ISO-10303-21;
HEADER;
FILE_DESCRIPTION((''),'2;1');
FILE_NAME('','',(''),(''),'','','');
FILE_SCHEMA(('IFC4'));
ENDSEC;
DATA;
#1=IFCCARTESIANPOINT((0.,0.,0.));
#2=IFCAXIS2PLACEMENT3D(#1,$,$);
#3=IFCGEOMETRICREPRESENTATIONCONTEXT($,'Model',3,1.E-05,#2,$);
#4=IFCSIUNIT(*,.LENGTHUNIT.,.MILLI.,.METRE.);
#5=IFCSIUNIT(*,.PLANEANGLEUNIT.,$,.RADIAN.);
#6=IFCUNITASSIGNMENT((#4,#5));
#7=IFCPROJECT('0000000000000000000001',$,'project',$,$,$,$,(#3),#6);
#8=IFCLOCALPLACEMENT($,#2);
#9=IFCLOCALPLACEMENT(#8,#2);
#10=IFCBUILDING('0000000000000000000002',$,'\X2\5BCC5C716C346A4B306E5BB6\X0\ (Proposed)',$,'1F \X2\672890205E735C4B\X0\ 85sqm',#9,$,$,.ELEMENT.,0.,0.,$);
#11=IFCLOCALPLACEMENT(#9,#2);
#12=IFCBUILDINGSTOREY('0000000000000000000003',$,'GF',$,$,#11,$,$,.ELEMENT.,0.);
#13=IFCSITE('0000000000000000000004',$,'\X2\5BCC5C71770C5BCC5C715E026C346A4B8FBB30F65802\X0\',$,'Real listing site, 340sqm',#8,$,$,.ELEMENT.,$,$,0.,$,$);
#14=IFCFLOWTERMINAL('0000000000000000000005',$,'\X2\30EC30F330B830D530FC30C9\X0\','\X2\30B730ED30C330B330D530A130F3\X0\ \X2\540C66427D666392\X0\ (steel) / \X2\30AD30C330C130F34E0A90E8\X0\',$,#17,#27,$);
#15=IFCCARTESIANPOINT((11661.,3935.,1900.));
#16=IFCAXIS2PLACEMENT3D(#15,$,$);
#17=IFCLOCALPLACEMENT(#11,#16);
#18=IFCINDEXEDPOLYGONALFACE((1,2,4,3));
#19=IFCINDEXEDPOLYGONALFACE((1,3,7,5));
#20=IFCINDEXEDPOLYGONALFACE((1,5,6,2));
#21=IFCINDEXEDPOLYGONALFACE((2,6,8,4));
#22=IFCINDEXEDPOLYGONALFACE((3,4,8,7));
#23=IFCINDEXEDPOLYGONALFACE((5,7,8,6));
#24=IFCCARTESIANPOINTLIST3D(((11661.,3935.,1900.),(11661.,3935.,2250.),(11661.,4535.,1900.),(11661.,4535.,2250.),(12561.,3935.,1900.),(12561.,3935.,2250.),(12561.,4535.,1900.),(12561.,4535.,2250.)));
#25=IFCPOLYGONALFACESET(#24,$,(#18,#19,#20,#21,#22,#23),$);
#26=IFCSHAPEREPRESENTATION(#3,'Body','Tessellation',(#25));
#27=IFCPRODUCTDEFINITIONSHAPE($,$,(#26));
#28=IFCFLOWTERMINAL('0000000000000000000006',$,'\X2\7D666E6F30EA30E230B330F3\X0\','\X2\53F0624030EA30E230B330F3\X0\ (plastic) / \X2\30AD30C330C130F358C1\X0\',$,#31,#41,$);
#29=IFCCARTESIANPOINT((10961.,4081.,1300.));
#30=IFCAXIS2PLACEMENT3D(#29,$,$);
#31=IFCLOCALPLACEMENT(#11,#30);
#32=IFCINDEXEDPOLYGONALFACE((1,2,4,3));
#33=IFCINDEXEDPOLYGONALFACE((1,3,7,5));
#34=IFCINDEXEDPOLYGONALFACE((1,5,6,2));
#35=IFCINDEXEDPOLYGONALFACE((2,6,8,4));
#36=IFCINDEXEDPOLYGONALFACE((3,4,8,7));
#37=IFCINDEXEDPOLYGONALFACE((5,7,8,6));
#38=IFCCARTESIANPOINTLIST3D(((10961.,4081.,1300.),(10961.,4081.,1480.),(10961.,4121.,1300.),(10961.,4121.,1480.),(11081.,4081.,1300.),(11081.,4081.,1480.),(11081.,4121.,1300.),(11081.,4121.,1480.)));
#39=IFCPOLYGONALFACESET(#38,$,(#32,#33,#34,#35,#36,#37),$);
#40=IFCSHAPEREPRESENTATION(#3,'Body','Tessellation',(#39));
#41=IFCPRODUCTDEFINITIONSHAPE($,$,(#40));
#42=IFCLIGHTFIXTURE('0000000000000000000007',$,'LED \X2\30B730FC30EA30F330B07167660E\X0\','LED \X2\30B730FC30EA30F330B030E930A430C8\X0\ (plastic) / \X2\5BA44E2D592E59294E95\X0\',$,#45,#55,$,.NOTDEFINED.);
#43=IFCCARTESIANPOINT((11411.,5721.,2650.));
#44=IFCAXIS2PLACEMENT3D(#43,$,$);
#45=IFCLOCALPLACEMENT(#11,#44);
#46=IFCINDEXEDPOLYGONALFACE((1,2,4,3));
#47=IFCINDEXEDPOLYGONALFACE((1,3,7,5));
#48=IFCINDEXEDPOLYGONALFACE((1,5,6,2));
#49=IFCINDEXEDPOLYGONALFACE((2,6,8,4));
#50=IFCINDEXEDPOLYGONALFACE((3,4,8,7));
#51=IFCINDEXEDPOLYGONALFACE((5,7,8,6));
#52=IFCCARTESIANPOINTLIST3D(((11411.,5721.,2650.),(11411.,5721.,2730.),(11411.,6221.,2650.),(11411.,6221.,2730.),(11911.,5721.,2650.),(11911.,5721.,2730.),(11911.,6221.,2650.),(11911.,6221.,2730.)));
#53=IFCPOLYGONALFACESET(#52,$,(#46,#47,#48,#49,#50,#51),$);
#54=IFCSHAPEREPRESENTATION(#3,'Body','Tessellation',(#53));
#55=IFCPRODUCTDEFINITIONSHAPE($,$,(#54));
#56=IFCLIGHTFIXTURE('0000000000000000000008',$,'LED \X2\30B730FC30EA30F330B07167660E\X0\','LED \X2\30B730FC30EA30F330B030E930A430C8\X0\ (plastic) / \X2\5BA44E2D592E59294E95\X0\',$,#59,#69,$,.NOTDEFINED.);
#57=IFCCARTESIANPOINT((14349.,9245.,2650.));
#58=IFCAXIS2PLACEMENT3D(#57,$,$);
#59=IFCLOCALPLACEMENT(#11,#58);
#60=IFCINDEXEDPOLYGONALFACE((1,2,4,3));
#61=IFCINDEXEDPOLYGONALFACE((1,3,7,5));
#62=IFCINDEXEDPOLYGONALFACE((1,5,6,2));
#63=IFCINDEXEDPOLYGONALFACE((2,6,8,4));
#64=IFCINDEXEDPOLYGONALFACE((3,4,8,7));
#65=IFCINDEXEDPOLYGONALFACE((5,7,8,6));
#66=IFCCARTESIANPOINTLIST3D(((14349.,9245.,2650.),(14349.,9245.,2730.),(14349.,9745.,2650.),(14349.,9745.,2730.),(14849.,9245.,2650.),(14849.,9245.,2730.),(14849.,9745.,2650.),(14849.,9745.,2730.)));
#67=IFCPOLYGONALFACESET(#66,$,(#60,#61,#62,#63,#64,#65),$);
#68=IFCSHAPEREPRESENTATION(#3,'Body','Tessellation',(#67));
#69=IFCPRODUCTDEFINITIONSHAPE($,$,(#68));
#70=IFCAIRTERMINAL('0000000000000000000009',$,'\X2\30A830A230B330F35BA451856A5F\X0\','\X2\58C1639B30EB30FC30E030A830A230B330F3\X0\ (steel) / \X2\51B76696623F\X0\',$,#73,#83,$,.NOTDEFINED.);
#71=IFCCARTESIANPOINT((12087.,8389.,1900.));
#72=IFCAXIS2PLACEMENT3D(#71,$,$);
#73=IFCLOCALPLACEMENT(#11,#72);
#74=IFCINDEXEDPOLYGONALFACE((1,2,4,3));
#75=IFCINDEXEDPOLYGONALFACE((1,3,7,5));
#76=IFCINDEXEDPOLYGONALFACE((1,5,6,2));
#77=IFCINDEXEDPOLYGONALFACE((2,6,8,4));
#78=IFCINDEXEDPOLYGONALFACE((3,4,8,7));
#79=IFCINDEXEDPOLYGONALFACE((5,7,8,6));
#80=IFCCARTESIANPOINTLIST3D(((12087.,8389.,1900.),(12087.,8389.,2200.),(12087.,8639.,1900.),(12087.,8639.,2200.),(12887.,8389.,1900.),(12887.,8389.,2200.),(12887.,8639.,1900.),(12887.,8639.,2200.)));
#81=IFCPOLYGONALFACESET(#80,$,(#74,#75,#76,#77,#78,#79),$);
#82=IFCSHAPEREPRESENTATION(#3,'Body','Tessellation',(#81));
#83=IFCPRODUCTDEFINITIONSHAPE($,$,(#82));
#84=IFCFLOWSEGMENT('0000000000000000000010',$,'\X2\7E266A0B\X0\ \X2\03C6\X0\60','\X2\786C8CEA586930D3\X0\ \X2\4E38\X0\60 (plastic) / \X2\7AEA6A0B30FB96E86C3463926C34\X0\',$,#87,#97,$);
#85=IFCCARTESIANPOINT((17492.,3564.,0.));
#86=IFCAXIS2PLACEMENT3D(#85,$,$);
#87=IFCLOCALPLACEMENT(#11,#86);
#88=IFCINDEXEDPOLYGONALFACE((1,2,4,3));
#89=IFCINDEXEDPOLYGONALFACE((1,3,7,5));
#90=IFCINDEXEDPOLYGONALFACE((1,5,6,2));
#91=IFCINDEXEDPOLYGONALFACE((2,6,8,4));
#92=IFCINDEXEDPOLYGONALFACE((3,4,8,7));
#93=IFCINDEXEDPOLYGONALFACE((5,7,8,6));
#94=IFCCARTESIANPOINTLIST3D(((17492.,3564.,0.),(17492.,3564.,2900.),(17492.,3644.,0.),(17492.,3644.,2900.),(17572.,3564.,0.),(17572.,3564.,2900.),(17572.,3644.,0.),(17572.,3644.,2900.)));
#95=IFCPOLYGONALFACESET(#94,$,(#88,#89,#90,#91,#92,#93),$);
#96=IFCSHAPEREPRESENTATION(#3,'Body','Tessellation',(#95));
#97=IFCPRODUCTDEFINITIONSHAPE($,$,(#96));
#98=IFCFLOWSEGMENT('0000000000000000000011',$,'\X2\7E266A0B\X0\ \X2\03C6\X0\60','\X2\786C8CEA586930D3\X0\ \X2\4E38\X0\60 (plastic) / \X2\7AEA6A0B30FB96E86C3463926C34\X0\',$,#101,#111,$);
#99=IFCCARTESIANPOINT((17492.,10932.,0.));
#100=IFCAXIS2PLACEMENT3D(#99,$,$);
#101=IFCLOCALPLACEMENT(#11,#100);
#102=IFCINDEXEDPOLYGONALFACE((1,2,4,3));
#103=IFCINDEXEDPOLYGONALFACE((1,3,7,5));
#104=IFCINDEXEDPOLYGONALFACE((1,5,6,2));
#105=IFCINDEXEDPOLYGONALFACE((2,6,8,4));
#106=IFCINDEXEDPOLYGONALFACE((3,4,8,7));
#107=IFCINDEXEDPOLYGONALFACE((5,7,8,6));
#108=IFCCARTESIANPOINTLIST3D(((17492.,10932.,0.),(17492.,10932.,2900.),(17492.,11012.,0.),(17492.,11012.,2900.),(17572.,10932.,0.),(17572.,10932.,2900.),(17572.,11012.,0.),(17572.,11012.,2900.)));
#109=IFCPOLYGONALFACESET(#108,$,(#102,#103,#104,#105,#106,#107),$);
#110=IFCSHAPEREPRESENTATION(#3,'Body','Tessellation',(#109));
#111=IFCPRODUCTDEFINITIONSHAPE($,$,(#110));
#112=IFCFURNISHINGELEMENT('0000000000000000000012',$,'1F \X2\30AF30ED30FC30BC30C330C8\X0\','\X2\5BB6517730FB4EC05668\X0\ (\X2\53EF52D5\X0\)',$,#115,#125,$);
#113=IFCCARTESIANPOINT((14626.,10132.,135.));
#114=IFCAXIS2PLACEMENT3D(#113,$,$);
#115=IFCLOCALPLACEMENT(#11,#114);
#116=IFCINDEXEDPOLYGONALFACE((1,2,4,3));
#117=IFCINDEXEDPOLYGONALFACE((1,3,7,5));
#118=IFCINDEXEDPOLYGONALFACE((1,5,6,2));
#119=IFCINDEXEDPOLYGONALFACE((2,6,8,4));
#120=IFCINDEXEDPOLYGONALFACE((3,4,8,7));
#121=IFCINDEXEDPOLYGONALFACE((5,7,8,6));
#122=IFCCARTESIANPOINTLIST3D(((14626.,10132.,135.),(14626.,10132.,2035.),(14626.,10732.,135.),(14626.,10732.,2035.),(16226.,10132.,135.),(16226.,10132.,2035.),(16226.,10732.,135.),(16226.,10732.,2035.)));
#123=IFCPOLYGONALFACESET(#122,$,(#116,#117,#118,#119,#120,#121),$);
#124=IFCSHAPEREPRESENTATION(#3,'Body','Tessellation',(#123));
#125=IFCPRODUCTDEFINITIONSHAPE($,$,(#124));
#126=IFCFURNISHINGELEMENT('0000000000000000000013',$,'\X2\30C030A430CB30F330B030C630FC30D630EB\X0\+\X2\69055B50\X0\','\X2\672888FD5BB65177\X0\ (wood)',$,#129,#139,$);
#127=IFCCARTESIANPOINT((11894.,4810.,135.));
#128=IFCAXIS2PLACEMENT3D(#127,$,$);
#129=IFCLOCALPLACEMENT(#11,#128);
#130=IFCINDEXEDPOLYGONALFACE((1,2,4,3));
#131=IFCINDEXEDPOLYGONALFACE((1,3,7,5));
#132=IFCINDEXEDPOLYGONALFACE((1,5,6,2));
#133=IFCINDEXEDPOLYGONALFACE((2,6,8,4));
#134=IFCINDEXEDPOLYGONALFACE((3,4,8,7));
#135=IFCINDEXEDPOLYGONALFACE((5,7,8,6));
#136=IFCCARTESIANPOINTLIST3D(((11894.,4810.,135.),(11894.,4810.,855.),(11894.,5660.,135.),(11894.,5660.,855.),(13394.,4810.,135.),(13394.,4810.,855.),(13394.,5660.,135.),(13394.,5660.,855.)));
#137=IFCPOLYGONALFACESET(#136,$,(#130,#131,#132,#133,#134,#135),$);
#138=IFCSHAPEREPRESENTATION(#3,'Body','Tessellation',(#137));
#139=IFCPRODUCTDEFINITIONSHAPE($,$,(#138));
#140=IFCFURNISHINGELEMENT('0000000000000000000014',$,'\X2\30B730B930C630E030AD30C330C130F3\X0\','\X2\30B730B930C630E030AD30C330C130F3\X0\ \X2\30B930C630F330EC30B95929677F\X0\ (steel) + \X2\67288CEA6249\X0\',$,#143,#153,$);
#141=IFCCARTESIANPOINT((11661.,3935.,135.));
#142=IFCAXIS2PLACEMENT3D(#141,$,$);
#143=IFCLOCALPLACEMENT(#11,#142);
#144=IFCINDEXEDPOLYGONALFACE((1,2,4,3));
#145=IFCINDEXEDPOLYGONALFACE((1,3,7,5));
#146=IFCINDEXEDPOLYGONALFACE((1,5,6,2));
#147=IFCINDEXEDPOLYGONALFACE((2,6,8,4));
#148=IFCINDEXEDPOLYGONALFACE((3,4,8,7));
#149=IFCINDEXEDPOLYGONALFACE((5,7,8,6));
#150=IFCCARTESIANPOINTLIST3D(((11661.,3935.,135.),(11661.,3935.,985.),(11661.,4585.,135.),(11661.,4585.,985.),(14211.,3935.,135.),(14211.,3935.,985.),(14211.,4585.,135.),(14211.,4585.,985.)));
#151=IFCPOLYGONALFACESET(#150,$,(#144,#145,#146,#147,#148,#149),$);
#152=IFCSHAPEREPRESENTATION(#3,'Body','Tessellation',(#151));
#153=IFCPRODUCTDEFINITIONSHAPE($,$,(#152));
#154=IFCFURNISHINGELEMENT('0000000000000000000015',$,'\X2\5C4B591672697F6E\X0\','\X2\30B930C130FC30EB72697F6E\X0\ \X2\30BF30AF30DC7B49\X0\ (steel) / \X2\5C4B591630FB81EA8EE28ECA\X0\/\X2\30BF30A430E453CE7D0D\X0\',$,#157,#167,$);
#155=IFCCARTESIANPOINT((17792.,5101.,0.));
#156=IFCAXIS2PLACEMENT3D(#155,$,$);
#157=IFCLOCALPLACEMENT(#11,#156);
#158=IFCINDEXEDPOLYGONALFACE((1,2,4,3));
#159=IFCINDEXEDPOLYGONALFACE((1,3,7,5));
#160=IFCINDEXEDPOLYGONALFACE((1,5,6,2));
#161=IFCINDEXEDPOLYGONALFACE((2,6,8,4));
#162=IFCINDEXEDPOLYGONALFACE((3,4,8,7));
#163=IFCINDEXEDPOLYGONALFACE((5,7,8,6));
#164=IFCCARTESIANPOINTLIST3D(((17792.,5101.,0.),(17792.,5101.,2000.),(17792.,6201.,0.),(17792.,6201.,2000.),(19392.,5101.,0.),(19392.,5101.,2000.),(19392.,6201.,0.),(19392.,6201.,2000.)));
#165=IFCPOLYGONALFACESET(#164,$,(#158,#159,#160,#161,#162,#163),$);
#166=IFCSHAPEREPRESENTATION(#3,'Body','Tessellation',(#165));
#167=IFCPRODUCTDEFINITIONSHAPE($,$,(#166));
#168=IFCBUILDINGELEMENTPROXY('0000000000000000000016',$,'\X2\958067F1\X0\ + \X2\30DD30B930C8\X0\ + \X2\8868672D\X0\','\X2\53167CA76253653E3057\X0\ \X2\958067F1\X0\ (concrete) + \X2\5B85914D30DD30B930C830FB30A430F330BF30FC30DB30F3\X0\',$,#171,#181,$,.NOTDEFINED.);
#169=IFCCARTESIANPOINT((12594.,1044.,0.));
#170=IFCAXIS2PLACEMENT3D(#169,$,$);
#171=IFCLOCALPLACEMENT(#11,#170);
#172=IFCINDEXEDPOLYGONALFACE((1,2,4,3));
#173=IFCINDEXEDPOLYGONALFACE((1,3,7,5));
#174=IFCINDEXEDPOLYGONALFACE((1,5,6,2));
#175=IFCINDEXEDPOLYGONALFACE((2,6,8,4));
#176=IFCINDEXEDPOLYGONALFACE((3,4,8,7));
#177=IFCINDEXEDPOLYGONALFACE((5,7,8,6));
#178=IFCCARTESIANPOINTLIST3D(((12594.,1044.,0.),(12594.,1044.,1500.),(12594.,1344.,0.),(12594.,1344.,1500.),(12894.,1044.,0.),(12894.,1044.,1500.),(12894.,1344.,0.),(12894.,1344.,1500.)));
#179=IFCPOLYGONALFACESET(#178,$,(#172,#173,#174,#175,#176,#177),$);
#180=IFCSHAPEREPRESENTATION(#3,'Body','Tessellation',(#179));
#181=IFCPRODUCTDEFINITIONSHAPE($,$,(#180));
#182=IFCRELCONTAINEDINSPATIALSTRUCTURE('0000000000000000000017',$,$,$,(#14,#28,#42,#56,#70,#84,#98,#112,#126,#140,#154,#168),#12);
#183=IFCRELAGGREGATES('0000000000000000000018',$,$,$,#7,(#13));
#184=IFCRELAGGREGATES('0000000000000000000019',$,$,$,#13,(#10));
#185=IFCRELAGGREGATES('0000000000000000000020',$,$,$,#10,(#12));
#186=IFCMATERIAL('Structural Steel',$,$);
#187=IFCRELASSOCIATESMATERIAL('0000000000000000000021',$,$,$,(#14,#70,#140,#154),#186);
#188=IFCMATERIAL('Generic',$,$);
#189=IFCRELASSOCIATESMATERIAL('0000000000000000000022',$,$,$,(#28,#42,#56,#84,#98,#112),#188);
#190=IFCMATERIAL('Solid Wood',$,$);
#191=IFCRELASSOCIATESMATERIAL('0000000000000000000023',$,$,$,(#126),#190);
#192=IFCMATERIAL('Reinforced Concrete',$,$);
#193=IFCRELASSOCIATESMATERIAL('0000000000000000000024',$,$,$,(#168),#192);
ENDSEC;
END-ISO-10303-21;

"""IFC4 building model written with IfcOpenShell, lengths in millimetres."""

from ifc_helpers import new_model, si_unit, frame, frame_2d, origin, place, context, project, spatial, rectangle, extrude, material, element, save


model = new_model("IFC4")

# Units and contexts
model_context = context("Model", 3, precision=1e-05, world=origin())
ifc_project = project(units=[si_unit("LENGTHUNIT", "METRE", prefix="MILLI"), si_unit("PLANEANGLEUNIT", "RADIAN")], contexts=[model_context])

# Site, building, storey
site_placement = place(None, origin())
site = spatial("IfcSite", under=ifc_project, at=site_placement, Name="富山県富山市水橋辻ヶ堂", ObjectType="Real listing site, 340sqm", CompositionType="ELEMENT", RefElevation=0.0)
building_placement = place(site_placement, origin())
building = spatial("IfcBuilding", under=site, at=building_placement, Name="富山水橋の家 (Proposed)", ObjectType="1F 木造平屋 85sqm", CompositionType="ELEMENT", ElevationOfRefHeight=0.0, ElevationOfTerrain=0.0)
storey_placement = place(building_placement, origin())
storey = spatial("IfcBuildingStorey", under=building, at=storey_placement, Name="GF", CompositionType="ELEMENT", Elevation=0.0)

# Shared definitions
ifc_material_1 = material(Name="Solid Wood")

# Shared definitions
ifc_material_2 = material(Name="Reinforced Concrete")

# Shared definitions
ifc_material_3 = material(Name="Generic")

# Shared definitions
ifc_material_4 = material(Name="Structural Steel")

# Flow terminals
flow_terminal_1_placement = place(storey_placement, frame((11661.0, 3935.0, 1900.0)))
element("IfcFlowTerminal", 1, at=flow_terminal_1_placement, inside=storey, material=ifc_material_4, Name="レンジフード", Description="シロッコファン 同時給排 (steel) / キッチン上部", context=model_context, shape_type="SweptSolid", body=[
    extrude(rectangle(XDim=900.0, YDim=600.0, at=frame_2d((450.0, 300.0))), frame((11661.0, 3935.0, 1900.0)), (0.0, 0.0, 1.0), 350.0),
])
flow_terminal_2_placement = place(storey_placement, frame((10961.0, 4081.0, 1300.0)))
element("IfcFlowTerminal", 2, at=flow_terminal_2_placement, inside=storey, material=ifc_material_3, Name="給湯リモコン", Description="台所リモコン (plastic) / キッチン壁", context=model_context, shape_type="SweptSolid", body=[
    extrude(rectangle(XDim=120.0, YDim=40.0, at=frame_2d((60.0, 20.0))), frame((10961.0, 4081.0, 1300.0)), (0.0, 0.0, 1.0), 180.0),
])

# Light fixtures
light_fixture_1_placement = place(storey_placement, frame((11411.0, 5721.0, 2650.0)))
element("IfcLightFixture", 3, at=light_fixture_1_placement, inside=storey, material=ifc_material_3, Name="LED シーリング照明", Description="LED シーリングライト (plastic) / 室中央天井", PredefinedType="NOTDEFINED", context=model_context, shape_type="SweptSolid", body=[
    extrude(rectangle(XDim=500.0, YDim=500.0, at=frame_2d((250.0, 250.0))), frame((11411.0, 5721.0, 2650.0)), (0.0, 0.0, 1.0), 80.0),
])
light_fixture_2_placement = place(storey_placement, frame((14349.0, 9245.0, 2650.0)))
element("IfcLightFixture", 4, at=light_fixture_2_placement, inside=storey, material=ifc_material_3, Name="LED シーリング照明", Description="LED シーリングライト (plastic) / 室中央天井", PredefinedType="NOTDEFINED", context=model_context, shape_type="SweptSolid", body=[
    extrude(rectangle(XDim=500.0, YDim=500.0, at=frame_2d((250.0, 250.0))), frame((14349.0, 9245.0, 2650.0)), (0.0, 0.0, 1.0), 80.0),
])

# Air terminal
air_terminal_placement = place(storey_placement, frame((12087.0, 8389.0, 1900.0)))
element("IfcAirTerminal", 5, at=air_terminal_placement, inside=storey, material=ifc_material_4, Name="エアコン室内機", Description="壁掛ルームエアコン (steel) / 冷暖房", PredefinedType="NOTDEFINED", context=model_context, shape_type="SweptSolid", body=[
    extrude(rectangle(XDim=800.0, YDim=250.0, at=frame_2d((400.0, 125.0))), frame((12087.0, 8389.0, 1900.0)), (0.0, 0.0, 1.0), 300.0),
])

# Flow segments
flow_segment_1_placement = place(storey_placement, frame((17492.0, 3564.0, 0.0)))
element("IfcFlowSegment", 6, at=flow_segment_1_placement, inside=storey, material=ifc_material_3, Name="縦樋 φ60", Description="硬質塩ビ 丸60 (plastic) / 竪樋・雨水排水", context=model_context, shape_type="SweptSolid", body=[
    extrude(rectangle(XDim=80.0, YDim=80.0, at=frame_2d((40.0, 40.0))), frame((17492.0, 3564.0, 0.0)), (0.0, 0.0, 1.0), 2900.0),
])
flow_segment_2_placement = place(storey_placement, frame((17492.0, 10932.0, 0.0)))
element("IfcFlowSegment", 7, at=flow_segment_2_placement, inside=storey, material=ifc_material_3, Name="縦樋 φ60", Description="硬質塩ビ 丸60 (plastic) / 竪樋・雨水排水", context=model_context, shape_type="SweptSolid", body=[
    extrude(rectangle(XDim=80.0, YDim=80.0, at=frame_2d((40.0, 40.0))), frame((17492.0, 10932.0, 0.0)), (0.0, 0.0, 1.0), 2900.0),
])

# Furnishing elements
furnishing_1_placement = place(storey_placement, frame((14626.0, 10132.0, 135.0)))
element("IfcFurnishingElement", 8, at=furnishing_1_placement, inside=storey, material=ifc_material_3, Name="1F クローゼット", Description="家具・什器 (可動)", context=model_context, shape_type="SweptSolid", body=[
    extrude(rectangle(XDim=1600.0, YDim=600.0, at=frame_2d((800.0, 300.0))), frame((14626.0, 10132.0, 135.0)), (0.0, 0.0, 1.0), 1900.0),
])
furnishing_2_placement = place(storey_placement, frame((11894.0, 4810.0, 135.0)))
element("IfcFurnishingElement", 9, at=furnishing_2_placement, inside=storey, material=ifc_material_1, Name="ダイニングテーブル+椅子", Description="木製家具 (wood)", context=model_context, shape_type="SweptSolid", body=[
    extrude(rectangle(XDim=1500.0, YDim=850.0, at=frame_2d((750.0, 425.0))), frame((11894.0, 4810.0, 135.0)), (0.0, 0.0, 1.0), 720.0),
])
furnishing_3_placement = place(storey_placement, frame((11661.0, 3935.0, 135.0)))
element("IfcFurnishingElement", 10, at=furnishing_3_placement, inside=storey, material=ifc_material_4, Name="システムキッチン", Description="システムキッチン ステンレス天板 (steel) + 木質扉", context=model_context, shape_type="SweptSolid", body=[
    extrude(rectangle(XDim=2550.0, YDim=650.0, at=frame_2d((1275.0, 325.0))), frame((11661.0, 3935.0, 135.0)), (0.0, 0.0, 1.0), 850.0),
])
furnishing_4_placement = place(storey_placement, frame((17792.0, 5101.0, 0.0)))
element("IfcFurnishingElement", 11, at=furnishing_4_placement, inside=storey, material=ifc_material_4, Name="屋外物置", Description="スチール物置 タクボ等 (steel) / 屋外・自転車/タイヤ収納", context=model_context, shape_type="SweptSolid", body=[
    extrude(rectangle(XDim=1600.0, YDim=1100.0, at=frame_2d((800.0, 550.0))), frame((17792.0, 5101.0, 0.0)), (0.0, 0.0, 1.0), 2000.0),
])

# Building element proxy
proxy_placement = place(storey_placement, frame((12594.0, 1044.0, 0.0)))
element("IfcBuildingElementProxy", 12, at=proxy_placement, inside=storey, material=ifc_material_2, Name="門柱 + ポスト + 表札", Description="化粧打放し 門柱 (concrete) + 宅配ポスト・インターホン", PredefinedType="NOTDEFINED", context=model_context, shape_type="SweptSolid", body=[
    extrude(rectangle(XDim=300.0, YDim=300.0, at=frame_2d((150.0, 150.0))), frame((12594.0, 1044.0, 0.0)), (0.0, 0.0, 1.0), 1500.0),
])

save(model, "model.ifc")
